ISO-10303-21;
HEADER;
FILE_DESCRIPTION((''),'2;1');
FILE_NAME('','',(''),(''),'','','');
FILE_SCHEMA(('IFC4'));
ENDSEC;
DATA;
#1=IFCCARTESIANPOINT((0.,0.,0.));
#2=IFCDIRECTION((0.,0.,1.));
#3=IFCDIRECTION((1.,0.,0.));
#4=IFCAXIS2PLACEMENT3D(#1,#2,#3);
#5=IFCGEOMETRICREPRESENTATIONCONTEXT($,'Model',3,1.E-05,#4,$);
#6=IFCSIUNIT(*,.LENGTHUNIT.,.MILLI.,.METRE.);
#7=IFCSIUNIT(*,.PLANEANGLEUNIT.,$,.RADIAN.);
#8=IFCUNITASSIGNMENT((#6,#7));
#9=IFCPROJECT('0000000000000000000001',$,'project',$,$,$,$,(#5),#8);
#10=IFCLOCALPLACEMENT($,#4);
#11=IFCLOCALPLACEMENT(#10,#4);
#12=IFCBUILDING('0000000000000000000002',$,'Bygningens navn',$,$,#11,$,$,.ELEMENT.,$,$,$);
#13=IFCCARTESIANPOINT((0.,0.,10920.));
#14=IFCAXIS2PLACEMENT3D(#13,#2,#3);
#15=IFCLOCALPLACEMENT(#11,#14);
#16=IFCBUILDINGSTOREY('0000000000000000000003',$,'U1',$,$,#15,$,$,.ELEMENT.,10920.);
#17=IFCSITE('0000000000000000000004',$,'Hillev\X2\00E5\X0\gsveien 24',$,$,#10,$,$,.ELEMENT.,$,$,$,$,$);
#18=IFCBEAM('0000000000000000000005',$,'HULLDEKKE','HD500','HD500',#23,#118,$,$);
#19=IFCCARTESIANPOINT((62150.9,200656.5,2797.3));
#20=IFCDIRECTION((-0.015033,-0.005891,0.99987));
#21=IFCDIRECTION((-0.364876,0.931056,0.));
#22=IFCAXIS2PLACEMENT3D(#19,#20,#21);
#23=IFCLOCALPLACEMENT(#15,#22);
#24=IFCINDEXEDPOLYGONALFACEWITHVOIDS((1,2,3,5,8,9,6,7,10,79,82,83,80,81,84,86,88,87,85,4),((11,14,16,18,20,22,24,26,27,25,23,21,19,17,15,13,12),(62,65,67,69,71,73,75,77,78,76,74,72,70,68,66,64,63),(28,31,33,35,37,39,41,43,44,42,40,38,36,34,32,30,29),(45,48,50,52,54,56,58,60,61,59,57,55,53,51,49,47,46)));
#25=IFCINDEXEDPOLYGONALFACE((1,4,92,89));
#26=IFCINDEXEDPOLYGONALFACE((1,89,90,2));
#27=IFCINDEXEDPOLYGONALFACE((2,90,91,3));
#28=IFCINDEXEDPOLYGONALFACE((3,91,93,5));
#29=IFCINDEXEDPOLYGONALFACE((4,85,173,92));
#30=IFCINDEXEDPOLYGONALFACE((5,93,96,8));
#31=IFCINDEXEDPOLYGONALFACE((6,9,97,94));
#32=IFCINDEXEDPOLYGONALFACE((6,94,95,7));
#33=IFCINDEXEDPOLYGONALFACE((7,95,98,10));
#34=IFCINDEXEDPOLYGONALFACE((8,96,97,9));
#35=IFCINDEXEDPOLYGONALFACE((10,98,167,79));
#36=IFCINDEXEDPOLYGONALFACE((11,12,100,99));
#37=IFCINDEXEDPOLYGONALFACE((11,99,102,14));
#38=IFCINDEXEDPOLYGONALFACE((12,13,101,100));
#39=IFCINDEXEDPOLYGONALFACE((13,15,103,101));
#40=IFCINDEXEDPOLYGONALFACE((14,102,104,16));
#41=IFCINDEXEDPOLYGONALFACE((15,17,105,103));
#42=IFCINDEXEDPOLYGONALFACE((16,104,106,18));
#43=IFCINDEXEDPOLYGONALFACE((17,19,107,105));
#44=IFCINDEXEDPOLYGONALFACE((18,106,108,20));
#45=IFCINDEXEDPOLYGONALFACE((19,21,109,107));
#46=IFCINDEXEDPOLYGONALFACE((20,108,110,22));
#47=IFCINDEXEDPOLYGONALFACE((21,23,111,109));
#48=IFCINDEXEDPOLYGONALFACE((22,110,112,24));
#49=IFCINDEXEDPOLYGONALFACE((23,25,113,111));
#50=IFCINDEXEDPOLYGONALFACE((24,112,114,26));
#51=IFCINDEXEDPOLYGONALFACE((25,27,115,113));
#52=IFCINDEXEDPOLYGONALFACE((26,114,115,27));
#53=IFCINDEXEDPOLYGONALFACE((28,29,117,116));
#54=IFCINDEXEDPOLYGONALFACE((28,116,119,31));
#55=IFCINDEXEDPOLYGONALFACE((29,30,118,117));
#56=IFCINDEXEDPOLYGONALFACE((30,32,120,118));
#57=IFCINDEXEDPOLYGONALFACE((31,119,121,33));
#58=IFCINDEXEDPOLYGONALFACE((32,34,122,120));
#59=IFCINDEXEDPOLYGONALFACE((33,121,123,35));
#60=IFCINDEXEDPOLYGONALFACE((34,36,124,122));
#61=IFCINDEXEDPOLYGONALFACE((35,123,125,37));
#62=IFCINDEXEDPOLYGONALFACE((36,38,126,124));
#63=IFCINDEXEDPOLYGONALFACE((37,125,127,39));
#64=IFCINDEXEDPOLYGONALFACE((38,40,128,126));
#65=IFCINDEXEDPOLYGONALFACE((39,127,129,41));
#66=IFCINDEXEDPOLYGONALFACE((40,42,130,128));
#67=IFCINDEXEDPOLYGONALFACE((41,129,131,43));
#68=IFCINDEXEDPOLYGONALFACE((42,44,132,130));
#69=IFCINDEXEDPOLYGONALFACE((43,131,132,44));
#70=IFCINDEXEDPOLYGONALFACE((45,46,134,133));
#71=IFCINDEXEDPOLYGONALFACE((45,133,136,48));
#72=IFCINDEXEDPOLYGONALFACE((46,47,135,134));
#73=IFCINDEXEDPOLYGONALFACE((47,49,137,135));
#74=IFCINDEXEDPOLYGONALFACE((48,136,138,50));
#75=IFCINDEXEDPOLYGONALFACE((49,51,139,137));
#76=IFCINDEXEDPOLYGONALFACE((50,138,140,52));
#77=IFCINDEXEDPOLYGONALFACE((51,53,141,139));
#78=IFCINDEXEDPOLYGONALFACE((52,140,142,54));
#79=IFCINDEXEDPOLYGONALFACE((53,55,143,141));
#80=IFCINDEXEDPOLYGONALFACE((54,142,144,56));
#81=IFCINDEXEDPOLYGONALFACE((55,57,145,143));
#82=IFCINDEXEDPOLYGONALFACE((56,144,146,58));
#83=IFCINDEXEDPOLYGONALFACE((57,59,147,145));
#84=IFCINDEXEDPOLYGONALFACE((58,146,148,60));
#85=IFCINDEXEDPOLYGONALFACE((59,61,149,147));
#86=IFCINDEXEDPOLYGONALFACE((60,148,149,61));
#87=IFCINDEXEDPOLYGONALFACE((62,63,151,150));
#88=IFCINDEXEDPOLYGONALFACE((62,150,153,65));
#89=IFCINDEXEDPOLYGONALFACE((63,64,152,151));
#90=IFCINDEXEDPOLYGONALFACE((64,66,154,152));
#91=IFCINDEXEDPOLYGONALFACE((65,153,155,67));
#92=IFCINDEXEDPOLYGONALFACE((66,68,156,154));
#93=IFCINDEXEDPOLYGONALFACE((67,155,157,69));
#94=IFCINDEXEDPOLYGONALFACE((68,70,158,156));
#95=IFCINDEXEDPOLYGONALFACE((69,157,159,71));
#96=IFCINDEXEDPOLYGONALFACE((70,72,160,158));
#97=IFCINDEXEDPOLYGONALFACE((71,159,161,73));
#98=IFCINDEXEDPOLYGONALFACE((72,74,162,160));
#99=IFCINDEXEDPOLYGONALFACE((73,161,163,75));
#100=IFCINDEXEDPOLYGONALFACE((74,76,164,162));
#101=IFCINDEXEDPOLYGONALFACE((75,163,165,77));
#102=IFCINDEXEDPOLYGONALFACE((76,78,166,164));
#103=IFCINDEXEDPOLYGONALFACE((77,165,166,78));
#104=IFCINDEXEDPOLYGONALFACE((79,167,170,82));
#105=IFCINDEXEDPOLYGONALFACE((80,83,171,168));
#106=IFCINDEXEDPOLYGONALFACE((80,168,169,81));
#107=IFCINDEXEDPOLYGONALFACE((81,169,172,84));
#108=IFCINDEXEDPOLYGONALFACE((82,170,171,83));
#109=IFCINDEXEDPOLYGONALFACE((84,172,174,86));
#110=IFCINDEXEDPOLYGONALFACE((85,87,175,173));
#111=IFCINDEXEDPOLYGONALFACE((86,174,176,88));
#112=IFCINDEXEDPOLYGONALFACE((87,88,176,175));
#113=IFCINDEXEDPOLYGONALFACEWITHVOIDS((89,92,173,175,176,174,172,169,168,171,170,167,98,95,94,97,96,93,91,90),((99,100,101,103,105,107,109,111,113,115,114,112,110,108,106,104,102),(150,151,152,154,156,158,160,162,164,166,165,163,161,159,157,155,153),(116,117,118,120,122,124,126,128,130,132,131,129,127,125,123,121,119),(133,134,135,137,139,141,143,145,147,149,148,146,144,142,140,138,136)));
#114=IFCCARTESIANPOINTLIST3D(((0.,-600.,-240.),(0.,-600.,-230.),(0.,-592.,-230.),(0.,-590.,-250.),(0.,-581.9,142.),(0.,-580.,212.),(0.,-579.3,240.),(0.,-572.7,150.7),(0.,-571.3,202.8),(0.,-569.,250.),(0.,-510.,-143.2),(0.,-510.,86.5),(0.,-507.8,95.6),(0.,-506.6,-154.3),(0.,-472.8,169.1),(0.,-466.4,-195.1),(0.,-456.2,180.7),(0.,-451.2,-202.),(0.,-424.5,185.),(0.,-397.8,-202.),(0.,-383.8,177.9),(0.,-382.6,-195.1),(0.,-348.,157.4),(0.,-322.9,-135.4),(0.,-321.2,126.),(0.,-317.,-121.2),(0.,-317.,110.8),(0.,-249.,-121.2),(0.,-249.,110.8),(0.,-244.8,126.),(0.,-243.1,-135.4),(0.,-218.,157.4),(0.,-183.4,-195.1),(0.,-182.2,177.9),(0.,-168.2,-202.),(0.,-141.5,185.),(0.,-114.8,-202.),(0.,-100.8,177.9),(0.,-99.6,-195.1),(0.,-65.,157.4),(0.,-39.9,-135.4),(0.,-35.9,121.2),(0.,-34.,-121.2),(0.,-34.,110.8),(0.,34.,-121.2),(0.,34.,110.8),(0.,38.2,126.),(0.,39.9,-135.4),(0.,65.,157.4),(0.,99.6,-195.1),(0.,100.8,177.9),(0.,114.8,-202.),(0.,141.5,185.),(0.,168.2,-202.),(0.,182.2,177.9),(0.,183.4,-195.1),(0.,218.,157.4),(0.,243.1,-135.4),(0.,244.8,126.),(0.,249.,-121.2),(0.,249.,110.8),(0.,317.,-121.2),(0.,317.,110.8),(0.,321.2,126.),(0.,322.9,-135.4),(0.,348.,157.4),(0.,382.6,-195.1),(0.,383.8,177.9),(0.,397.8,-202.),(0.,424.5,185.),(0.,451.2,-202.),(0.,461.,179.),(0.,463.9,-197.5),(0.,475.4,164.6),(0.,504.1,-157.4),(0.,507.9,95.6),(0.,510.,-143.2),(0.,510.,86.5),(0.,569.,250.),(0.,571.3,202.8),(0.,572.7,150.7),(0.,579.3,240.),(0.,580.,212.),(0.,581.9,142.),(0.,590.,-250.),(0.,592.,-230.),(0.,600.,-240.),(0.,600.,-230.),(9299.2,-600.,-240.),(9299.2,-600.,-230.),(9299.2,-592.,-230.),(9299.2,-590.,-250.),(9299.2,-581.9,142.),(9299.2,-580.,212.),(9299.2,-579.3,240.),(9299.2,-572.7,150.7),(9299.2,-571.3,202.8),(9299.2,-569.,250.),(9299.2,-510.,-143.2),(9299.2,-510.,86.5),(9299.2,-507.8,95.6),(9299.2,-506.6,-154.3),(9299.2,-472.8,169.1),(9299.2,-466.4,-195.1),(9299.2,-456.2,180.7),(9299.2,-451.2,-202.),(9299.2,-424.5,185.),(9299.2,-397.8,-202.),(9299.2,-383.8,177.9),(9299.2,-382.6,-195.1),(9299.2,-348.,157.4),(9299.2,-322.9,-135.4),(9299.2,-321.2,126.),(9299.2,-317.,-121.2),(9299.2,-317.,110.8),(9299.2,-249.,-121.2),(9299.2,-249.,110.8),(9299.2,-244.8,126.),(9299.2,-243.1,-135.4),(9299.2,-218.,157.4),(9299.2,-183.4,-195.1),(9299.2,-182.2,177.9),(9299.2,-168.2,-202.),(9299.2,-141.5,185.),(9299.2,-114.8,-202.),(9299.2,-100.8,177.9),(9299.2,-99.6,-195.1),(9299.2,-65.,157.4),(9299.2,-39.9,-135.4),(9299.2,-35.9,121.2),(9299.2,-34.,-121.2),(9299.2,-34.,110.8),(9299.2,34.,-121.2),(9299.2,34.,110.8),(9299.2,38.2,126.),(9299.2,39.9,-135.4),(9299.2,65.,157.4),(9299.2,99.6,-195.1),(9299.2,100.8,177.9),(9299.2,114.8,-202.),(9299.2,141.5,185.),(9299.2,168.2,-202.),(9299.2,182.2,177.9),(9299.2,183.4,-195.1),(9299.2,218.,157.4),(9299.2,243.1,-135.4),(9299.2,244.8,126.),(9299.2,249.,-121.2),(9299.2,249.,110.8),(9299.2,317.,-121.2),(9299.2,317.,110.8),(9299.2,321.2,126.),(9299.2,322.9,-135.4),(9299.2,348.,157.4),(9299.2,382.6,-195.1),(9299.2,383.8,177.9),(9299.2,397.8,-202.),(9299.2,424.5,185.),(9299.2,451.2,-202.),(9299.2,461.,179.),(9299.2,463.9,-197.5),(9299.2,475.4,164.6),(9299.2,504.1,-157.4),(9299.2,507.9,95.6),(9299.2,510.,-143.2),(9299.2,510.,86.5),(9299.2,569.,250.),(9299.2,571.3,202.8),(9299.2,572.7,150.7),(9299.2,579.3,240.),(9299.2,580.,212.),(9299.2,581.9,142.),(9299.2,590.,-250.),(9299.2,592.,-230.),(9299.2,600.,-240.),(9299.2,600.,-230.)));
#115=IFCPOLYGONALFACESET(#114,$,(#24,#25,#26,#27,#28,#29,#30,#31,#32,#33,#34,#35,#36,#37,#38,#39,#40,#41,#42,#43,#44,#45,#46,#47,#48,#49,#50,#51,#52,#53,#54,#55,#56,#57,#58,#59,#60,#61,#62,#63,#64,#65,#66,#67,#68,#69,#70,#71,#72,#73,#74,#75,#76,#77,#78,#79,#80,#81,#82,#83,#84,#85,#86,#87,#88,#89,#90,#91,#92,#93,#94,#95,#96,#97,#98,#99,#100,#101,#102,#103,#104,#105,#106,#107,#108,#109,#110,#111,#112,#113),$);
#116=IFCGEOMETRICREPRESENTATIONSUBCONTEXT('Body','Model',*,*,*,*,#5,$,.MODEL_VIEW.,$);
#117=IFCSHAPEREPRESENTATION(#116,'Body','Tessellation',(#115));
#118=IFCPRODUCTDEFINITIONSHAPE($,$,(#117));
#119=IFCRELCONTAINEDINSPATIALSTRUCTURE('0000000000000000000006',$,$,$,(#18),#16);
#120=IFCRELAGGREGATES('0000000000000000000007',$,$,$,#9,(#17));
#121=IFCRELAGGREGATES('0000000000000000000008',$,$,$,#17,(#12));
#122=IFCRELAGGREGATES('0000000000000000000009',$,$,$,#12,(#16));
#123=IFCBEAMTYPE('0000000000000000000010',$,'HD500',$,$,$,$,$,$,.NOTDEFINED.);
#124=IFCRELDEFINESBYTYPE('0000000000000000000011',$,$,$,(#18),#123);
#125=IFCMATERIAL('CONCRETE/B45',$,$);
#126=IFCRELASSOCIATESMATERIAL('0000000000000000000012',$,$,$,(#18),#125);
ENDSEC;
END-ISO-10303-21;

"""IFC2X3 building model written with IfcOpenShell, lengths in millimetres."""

from ifc_helpers import new_model, si_unit, frame, origin_with_axes, place, context, subcontext, project, spatial, polyline, outline, extrude, material, type_object, element, save


model = new_model("IFC2X3")

# Units and contexts
model_context = context("Model", 3, precision=1e-05, world=origin_with_axes())
body_context = subcontext(model_context, "Body", "Model", "MODEL_VIEW")
ifc_project = project(units=[si_unit("LENGTHUNIT", "METRE", prefix="MILLI"), si_unit("PLANEANGLEUNIT", "RADIAN")], contexts=[model_context])

# Site, building, storey
site_placement = place(None, origin_with_axes())
site = spatial("IfcSite", under=ifc_project, at=site_placement, Name="Hillevågsveien 24", CompositionType="ELEMENT")
building_placement = place(site_placement, origin_with_axes())
building = spatial("IfcBuilding", under=site, at=building_placement, Name="Bygningens navn", CompositionType="ELEMENT")
storey_placement = place(building_placement, frame((0.0, 0.0, 10920.0), z_axis=(0.0, 0.0, 1.0), x_axis=(1.0, 0.0, 0.0)))
storey = spatial("IfcBuildingStorey", under=building, at=storey_placement, Name="U1", CompositionType="ELEMENT", Elevation=10920.0)

# Beam
ifc_material_1 = material(Name="CONCRETE/B45")
beam_type_1 = type_object("IfcBeamType", Name="HD500", PredefinedType="NOTDEFINED")
beam_1_placement = place(storey_placement, frame((62150.9, 200656.5, 2797.3), z_axis=(-0.015033, -0.005891, 0.99987), x_axis=(-0.364876, 0.931056, 0.0)))
element("IfcBeam", 1, at=beam_1_placement, inside=storey, type_object=beam_type_1, material=ifc_material_1, Name="HULLDEKKE", Description="HD500", ObjectType="HD500", context=body_context, shape_type="SweptSolid", body=[
    extrude(outline(polyline([(581.9, 142.0), (592.0, -230.0), (600.0, -230.0), (600.0, -240.0), (590.0, -250.0), (-590.0, -250.0), (-600.0, -240.0), (-600.0, -230.0), (-592.0, -230.0), (-581.9, 142.0), (-572.7, 150.7), (-571.3, 202.8), (-580.0, 212.0), (-579.3, 240.0), (-569.0, 250.0), (569.0, 250.0), (579.3, 240.0), (580.0, 212.0), (571.3, 202.8), (572.7, 150.7), (581.9, 142.0)]), holes=[polyline([(466.4, -195.1), (506.6, -154.3), (510.0, -143.2), (510.0, 86.5), (507.8, 95.6), (472.8, 169.1), (456.2, 180.7), (424.5, 185.0), (383.8, 177.9), (348.0, 157.4), (321.2, 126.0), (317.0, 110.8), (317.0, -121.2), (322.9, -135.4), (382.6, -195.1), (397.8, -202.0), (451.2, -202.0), (466.4, -195.1)]), polyline([(183.4, -195.1), (243.1, -135.4), (249.0, -121.2), (249.0, 110.8), (244.8, 126.0), (218.0, 157.4), (182.2, 177.9), (141.5, 185.0), (100.8, 177.9), (65.0, 157.4), (35.9, 121.2), (34.0, 110.8), (34.0, -121.2), (39.9, -135.4), (99.6, -195.1), (114.8, -202.0), (168.2, -202.0), (183.4, -195.1)]), polyline([(-99.6, -195.1), (-39.9, -135.4), (-34.0, -121.2), (-34.0, 110.8), (-38.2, 126.0), (-65.0, 157.4), (-100.8, 177.9), (-141.5, 185.0), (-182.2, 177.9), (-218.0, 157.4), (-244.8, 126.0), (-249.0, 110.8), (-249.0, -121.2), (-243.1, -135.4), (-183.4, -195.1), (-168.2, -202.0), (-114.8, -202.0), (-99.6, -195.1)]), polyline([(-382.6, -195.1), (-322.9, -135.4), (-317.0, -121.2), (-317.0, 110.8), (-321.2, 126.0), (-348.0, 157.4), (-383.8, 177.9), (-424.5, 185.0), (-461.0, 179.0), (-475.4, 164.6), (-507.9, 95.6), (-510.0, 86.5), (-510.0, -143.2), (-504.1, -157.4), (-463.9, -197.5), (-451.2, -202.0), (-397.8, -202.0), (-382.6, -195.1)])]), frame((9299.2, 0.0, 0.0), z_axis=(-1.0, 0.0, 0.0), x_axis=(0.0, -1.0, 0.0)), (0.0, 0.0, 1.0), 9299.2),
])

save(model, "model.ifc")
